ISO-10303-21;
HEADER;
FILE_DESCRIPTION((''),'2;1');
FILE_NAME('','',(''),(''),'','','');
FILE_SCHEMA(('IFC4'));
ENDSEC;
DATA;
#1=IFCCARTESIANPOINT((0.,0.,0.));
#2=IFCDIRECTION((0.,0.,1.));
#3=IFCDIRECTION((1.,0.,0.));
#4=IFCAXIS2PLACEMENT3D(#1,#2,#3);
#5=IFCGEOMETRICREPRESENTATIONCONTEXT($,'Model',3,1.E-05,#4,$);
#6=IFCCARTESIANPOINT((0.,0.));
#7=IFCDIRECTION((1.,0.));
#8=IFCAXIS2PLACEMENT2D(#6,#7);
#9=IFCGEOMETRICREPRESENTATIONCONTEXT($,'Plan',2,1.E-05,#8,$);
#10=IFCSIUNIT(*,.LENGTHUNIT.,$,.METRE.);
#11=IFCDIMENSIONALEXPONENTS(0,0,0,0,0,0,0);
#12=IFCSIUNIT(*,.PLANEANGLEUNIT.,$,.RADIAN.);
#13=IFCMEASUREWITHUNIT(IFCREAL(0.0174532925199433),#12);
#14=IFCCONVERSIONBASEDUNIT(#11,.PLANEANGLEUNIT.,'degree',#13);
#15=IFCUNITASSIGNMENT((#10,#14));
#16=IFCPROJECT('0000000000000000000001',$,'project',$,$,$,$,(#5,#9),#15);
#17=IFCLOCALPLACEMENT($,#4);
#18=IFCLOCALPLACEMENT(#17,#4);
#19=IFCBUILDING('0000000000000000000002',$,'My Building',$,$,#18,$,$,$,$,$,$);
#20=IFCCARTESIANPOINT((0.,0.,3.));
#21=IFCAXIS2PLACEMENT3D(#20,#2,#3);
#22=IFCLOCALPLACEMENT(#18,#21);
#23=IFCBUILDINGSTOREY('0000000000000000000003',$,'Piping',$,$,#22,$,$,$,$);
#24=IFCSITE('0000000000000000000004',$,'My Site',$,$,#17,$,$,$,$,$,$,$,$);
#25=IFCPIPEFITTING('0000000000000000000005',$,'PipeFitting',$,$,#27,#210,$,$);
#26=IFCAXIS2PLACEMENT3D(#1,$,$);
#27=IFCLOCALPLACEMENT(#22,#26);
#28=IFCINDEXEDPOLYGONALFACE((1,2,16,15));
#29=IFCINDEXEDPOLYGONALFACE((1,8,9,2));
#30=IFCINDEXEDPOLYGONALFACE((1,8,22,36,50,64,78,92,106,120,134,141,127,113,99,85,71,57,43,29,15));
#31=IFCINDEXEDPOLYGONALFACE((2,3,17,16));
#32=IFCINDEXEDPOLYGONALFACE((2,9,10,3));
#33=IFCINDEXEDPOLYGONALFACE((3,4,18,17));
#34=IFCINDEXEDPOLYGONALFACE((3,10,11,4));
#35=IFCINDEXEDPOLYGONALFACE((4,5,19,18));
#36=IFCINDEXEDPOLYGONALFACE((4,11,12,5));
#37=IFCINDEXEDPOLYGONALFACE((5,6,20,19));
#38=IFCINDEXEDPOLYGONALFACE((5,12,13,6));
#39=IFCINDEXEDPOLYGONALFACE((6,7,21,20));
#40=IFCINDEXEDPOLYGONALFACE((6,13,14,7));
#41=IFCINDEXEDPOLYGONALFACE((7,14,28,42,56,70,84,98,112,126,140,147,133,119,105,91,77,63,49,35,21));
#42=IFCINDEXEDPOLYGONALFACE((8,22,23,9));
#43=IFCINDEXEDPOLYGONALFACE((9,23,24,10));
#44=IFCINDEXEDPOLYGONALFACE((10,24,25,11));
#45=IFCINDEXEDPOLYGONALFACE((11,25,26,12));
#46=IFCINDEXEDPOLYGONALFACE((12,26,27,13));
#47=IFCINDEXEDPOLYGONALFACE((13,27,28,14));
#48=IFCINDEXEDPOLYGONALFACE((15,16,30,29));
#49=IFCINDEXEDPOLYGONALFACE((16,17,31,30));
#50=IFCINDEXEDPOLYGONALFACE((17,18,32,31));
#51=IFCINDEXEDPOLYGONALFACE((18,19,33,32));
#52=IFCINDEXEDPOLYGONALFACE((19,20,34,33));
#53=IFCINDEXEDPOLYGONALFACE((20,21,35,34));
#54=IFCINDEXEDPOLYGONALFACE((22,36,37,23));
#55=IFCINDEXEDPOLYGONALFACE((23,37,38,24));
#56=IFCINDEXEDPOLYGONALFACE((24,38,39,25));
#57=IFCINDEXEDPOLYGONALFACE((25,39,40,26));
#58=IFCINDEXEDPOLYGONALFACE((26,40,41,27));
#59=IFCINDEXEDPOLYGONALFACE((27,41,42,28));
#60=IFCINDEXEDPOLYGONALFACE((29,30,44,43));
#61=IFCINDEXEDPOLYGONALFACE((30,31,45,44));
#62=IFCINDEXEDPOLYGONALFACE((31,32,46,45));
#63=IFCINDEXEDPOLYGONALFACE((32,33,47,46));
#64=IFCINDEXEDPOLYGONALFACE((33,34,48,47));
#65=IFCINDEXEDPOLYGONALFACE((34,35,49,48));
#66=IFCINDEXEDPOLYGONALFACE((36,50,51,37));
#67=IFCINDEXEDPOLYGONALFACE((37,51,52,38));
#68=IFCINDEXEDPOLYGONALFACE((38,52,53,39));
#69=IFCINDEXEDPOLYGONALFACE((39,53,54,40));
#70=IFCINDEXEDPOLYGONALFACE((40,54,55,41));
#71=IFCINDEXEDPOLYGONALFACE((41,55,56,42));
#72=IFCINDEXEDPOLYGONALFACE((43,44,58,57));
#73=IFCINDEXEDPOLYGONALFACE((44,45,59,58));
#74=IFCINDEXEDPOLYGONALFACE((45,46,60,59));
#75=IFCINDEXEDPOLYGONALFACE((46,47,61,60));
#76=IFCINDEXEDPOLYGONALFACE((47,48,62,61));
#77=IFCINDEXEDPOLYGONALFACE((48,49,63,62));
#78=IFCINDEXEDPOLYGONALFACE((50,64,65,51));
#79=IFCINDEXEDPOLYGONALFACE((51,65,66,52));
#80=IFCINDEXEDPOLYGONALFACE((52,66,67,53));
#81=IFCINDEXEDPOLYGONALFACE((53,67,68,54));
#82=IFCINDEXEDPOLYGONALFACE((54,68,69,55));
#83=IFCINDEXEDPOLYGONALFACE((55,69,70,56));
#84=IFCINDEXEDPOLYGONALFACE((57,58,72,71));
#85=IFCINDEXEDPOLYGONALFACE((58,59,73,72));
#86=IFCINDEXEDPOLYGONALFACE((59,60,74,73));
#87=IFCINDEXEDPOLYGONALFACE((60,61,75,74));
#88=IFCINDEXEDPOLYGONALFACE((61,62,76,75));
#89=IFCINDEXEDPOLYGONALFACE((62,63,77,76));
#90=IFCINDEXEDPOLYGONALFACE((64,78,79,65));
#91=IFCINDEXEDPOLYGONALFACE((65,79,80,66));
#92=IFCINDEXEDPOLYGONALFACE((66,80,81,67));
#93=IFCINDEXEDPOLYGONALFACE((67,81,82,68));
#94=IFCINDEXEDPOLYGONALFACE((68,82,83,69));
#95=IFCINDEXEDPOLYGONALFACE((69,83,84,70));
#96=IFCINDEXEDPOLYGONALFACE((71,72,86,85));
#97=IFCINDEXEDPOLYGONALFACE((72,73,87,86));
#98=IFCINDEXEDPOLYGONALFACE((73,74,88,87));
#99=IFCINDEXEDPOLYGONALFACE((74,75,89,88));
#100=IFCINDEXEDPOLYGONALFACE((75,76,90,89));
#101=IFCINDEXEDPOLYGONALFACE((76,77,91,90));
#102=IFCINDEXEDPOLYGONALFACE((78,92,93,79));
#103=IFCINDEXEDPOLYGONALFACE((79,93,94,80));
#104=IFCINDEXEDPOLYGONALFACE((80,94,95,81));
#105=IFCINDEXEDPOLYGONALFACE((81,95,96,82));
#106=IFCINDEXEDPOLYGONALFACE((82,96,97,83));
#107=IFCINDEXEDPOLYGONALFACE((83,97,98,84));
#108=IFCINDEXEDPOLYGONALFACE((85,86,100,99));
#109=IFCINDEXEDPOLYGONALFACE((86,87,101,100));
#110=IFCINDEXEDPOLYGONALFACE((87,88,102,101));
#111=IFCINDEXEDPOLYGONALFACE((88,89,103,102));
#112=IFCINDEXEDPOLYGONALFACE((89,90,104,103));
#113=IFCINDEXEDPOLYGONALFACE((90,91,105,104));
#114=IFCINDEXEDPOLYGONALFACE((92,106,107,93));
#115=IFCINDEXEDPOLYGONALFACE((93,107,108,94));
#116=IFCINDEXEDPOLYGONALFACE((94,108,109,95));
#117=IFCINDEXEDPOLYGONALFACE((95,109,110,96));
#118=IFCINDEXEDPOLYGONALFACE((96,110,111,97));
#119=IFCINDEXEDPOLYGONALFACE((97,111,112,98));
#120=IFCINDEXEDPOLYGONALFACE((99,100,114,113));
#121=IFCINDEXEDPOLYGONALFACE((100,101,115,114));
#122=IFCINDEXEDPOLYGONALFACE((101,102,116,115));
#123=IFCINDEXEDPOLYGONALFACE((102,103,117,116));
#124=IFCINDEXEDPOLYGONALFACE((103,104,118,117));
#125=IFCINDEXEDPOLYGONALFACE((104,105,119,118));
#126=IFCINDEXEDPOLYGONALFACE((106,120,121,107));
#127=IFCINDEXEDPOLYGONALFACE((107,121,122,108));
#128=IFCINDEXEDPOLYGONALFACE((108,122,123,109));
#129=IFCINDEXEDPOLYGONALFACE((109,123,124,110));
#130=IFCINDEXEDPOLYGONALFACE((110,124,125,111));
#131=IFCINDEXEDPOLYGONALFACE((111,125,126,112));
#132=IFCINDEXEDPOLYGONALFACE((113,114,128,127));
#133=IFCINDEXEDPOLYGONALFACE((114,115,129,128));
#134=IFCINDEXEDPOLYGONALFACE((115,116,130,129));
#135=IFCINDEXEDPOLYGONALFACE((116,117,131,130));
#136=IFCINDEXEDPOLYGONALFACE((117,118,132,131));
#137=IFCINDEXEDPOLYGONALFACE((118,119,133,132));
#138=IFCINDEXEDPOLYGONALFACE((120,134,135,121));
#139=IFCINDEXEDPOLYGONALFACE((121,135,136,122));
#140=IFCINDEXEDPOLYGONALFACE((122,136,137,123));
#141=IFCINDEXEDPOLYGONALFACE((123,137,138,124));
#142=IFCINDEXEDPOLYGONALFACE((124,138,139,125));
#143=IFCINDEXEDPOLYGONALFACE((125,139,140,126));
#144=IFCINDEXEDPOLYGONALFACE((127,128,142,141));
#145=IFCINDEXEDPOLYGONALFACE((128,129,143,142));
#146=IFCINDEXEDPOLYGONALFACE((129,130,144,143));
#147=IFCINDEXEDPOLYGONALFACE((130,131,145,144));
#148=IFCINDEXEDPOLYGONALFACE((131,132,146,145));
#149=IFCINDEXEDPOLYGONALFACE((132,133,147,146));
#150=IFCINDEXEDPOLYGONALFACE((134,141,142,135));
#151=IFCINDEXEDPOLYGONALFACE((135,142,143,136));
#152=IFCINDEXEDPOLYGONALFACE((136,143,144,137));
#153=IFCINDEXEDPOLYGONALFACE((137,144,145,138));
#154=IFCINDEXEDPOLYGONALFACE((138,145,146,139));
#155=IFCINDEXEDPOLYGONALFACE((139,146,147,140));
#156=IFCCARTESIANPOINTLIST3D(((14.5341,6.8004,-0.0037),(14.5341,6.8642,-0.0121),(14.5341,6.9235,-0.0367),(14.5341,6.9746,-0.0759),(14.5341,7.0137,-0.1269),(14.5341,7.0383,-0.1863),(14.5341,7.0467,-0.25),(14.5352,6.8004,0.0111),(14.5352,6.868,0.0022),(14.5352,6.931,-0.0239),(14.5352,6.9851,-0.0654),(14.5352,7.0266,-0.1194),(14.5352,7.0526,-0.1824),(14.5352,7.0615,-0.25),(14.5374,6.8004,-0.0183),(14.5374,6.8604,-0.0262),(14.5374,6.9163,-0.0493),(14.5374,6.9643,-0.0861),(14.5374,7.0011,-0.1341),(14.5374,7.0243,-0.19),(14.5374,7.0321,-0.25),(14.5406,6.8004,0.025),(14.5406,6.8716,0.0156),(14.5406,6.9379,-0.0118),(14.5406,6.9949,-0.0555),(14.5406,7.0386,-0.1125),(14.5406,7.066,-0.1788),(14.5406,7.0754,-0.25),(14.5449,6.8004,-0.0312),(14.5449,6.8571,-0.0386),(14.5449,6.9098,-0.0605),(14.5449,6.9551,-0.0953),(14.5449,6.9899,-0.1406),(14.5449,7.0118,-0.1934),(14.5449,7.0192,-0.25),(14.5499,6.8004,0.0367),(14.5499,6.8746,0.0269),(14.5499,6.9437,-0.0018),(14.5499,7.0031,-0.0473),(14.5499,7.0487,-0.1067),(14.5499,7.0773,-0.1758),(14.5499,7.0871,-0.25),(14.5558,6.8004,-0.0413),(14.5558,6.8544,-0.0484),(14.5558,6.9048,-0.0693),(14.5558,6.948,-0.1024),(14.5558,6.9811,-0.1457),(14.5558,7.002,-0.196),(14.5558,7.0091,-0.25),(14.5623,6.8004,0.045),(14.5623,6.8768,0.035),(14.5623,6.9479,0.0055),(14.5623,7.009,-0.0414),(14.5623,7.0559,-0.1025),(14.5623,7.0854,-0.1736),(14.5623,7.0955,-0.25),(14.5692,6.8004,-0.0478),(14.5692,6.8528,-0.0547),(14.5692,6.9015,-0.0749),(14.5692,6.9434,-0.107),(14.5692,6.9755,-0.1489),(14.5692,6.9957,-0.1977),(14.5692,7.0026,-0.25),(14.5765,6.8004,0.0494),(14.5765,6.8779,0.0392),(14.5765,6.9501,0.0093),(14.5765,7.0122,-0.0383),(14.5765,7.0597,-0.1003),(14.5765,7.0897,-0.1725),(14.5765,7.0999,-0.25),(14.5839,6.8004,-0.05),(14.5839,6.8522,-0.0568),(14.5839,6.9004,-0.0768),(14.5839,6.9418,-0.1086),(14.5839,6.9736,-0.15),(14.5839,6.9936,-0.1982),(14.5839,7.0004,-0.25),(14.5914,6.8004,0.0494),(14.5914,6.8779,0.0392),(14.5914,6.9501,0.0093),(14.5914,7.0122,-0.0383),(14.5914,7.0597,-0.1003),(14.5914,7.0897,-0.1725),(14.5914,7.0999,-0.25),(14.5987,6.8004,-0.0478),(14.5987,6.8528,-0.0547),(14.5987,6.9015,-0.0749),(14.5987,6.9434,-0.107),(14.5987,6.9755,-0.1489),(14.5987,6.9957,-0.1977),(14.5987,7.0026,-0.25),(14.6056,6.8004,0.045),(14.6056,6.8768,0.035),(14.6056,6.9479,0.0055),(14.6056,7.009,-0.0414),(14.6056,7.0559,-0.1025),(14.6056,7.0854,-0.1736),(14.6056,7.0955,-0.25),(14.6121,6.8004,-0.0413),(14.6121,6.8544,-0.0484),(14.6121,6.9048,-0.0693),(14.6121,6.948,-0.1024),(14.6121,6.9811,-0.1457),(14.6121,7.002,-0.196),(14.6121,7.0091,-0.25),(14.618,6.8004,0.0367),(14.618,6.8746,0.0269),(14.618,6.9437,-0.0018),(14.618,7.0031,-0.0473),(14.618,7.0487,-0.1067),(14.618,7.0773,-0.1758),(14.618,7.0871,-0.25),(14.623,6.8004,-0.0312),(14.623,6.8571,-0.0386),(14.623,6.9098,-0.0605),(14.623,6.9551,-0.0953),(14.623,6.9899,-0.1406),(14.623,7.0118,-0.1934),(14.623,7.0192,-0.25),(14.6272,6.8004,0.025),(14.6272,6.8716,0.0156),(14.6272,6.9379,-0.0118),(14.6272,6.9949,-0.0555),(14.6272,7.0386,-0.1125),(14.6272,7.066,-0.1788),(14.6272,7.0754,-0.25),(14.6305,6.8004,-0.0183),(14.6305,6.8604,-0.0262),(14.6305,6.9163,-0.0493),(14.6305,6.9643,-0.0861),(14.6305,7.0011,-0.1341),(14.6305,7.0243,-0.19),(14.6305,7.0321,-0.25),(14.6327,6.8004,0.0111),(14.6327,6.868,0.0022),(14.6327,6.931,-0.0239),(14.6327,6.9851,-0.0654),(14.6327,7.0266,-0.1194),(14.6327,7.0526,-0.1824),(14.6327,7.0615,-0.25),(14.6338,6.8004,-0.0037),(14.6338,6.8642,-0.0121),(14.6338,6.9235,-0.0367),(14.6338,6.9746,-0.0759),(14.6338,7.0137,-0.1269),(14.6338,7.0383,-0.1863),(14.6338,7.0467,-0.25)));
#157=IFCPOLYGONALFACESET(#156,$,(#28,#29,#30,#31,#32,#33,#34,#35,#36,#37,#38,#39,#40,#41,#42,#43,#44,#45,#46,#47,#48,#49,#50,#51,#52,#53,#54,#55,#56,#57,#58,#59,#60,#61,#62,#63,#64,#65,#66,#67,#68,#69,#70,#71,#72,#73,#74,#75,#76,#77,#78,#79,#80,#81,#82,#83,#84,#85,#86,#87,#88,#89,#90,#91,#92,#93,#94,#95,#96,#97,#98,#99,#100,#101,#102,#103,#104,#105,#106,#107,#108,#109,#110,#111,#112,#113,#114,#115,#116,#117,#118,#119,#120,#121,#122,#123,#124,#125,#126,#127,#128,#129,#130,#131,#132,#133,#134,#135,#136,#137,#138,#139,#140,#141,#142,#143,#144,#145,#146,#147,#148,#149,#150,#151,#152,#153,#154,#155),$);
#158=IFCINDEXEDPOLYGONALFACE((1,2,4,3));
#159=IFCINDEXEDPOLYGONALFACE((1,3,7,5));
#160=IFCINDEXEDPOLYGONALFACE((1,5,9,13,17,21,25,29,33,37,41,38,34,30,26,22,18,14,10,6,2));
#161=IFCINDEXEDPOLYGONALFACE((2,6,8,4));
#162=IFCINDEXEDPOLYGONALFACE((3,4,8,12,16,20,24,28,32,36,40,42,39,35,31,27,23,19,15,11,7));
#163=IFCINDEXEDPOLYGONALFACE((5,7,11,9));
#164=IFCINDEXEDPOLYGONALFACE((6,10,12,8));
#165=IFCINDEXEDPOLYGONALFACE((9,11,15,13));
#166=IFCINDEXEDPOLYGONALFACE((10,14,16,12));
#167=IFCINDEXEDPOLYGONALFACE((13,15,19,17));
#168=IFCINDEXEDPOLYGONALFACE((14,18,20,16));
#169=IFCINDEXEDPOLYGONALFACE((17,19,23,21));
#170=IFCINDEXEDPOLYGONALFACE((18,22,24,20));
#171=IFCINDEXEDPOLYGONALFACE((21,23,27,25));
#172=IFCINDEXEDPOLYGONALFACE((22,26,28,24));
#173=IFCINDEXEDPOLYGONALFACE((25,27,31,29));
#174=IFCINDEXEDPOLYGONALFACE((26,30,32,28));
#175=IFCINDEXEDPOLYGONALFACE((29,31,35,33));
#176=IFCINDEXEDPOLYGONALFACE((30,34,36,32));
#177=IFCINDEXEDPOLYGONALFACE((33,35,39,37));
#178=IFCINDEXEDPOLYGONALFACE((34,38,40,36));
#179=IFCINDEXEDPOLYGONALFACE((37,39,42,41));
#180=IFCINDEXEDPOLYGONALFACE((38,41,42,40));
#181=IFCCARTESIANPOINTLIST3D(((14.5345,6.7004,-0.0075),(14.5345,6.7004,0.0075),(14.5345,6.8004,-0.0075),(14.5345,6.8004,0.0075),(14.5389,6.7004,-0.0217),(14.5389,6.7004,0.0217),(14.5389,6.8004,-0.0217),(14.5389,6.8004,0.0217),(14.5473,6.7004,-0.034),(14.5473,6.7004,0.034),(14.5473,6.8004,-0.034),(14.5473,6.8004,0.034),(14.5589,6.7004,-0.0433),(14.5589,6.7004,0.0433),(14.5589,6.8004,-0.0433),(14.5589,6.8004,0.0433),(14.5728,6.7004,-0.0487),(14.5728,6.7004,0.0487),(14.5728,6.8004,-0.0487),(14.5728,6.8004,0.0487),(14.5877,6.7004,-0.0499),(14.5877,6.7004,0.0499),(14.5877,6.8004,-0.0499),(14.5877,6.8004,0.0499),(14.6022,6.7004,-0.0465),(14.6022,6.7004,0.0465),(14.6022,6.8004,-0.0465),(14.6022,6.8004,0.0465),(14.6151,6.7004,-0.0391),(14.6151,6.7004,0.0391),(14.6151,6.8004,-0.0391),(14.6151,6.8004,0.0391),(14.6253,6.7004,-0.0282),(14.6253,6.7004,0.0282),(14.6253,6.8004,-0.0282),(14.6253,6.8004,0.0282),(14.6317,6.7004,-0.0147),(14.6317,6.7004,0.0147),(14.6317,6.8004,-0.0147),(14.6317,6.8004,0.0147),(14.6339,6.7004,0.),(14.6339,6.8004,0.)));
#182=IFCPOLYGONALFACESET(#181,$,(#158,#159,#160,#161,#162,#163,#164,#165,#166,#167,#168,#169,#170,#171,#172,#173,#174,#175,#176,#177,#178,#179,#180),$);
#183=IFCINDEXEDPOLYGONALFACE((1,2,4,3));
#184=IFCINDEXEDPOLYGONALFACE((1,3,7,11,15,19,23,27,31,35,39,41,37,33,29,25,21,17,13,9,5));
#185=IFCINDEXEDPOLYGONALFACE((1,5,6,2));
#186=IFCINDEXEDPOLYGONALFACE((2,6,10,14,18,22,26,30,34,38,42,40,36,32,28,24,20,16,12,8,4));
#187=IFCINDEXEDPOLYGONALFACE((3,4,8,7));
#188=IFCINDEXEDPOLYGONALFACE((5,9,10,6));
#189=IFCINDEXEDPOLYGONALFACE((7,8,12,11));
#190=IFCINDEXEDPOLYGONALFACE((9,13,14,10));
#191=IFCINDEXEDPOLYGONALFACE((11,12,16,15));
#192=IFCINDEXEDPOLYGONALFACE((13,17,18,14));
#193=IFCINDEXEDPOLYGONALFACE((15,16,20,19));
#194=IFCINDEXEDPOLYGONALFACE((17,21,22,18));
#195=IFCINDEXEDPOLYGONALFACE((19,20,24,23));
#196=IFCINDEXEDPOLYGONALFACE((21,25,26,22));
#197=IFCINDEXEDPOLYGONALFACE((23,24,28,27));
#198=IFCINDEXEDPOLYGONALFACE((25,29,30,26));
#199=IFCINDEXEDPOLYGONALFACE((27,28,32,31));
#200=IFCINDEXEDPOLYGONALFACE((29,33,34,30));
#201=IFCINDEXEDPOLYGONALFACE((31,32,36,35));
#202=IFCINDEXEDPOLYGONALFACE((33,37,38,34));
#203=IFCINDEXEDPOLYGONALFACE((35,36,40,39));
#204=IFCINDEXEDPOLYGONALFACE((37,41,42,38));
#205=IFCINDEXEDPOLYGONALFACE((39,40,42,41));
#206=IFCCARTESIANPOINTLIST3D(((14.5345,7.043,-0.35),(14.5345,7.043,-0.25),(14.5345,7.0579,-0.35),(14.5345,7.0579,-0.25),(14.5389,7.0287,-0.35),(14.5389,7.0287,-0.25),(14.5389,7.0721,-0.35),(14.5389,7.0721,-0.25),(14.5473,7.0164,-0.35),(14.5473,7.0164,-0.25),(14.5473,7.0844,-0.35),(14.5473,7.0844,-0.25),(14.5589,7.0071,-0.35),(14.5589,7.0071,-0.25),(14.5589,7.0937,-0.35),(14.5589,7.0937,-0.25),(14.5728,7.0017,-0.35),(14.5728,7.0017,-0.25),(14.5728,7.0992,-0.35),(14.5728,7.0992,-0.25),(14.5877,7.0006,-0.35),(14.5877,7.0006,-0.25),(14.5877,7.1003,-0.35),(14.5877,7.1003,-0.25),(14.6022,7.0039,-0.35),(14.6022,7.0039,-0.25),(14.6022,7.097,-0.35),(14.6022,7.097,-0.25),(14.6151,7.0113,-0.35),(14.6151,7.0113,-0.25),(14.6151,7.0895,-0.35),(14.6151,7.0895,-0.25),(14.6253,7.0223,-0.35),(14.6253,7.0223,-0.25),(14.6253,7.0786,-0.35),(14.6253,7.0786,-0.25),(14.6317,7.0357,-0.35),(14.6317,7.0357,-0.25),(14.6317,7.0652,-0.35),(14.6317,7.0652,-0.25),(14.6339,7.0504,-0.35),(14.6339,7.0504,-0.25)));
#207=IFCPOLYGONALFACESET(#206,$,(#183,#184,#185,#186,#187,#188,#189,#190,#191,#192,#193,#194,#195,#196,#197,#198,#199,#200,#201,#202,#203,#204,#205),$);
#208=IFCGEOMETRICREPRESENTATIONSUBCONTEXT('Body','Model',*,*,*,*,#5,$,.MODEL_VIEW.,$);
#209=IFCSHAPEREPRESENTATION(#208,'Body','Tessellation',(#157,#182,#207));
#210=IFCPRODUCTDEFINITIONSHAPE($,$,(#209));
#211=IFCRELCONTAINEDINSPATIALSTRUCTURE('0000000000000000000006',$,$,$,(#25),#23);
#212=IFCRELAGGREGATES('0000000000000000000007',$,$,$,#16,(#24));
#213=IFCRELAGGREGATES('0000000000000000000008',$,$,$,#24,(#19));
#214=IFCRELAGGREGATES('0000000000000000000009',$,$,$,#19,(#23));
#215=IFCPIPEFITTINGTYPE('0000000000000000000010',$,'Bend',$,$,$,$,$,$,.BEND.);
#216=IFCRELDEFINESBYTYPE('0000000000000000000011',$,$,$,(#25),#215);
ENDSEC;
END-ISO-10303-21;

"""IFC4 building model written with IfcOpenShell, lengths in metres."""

from ifc_helpers import new_model, entity, si_unit, converted_unit, frame, origin_with_axes, origin_2d_with_axis, place, context, subcontext, project, spatial, circle, extrude, source, transform, mapped, type_object, type_shapes, element, save


model = new_model("IFC4")

# Units and contexts
model_context = context("Model", 3, precision=1e-05, world=origin_with_axes())
plan_context = context("Plan", 2, precision=1e-05, world=origin_2d_with_axis())
body_context = subcontext(model_context, "Body", "Model", "MODEL_VIEW")
ifc_project = project(units=[si_unit("LENGTHUNIT", "METRE"), converted_unit("PLANEANGLEUNIT", "degree", entity("IfcReal", 0.0174532925199433), si_unit("PLANEANGLEUNIT", "RADIAN"), dimensions=[0, 0, 0, 0, 0, 0, 0])], contexts=[model_context, plan_context])

# Site, building, storey
site_placement = place(None, origin_with_axes())
site = spatial("IfcSite", under=ifc_project, at=site_placement, Name="My Site")
building_placement = place(site_placement, origin_with_axes())
building = spatial("IfcBuilding", under=site, at=building_placement, Name="My Building")
storey_placement = place(building_placement, frame((0.0, 0.0, 3.0), z_axis=(0.0, 0.0, 1.0), x_axis=(1.0, 0.0, 0.0)))
storey = spatial("IfcBuildingStorey", under=building, at=storey_placement, Name="Piping")

# Pipe fitting
pipe_fitting_type = type_object("IfcPipeFittingType", Name="Bend", PredefinedType="BEND")
shared_shape = source(origin_with_axes(), body_context, "Body", "SolidModel", [
    entity("IfcSweptDiskSolid", entity("IfcIndexedPolyCurve", entity("IfcCartesianPointList3D", [[0.0, 0.0, -0.1], [0.0, -0.0732, -0.2768], [0.0, -0.25, -0.35]]), [entity("IfcArcIndex", [1, 2, 3])]), 0.05),
    extrude(circle(Radius=0.05), origin_with_axes(), (0.0, 0.0, -1.0), 0.1),
    extrude(circle(Radius=0.05), frame((0.0, -0.25, -0.35), z_axis=(0.0, -1.0, 0.0), x_axis=(1.0, 0.0, 0.0)), (0.0, 0.0, 1.0), 0.1),
])
type_shapes(pipe_fitting_type, [shared_shape])
for number, where, z_axis, x_axis, name in (
    (1, (14.5839, 6.7004, 0.0), (0.0, -1.0, 0.0), (1.0, 0.0, 0.0), "PipeFitting"),
):
    element("IfcPipeFitting", number, at=place(storey_placement, frame(where, z_axis=z_axis, x_axis=x_axis)), inside=storey, type_object=pipe_fitting_type, Name=name, context=body_context, shape_type="MappedRepresentation", body=[
        mapped(shared_shape, transform((0.0, 0.0, 0.0), x_axis=(1.0, 0.0, 0.0), y_axis=(0.0, 1.0, 0.0), z_axis=(0.0, 0.0, 1.0), scale=1.0)),
    ])

save(model, "model.ifc")
